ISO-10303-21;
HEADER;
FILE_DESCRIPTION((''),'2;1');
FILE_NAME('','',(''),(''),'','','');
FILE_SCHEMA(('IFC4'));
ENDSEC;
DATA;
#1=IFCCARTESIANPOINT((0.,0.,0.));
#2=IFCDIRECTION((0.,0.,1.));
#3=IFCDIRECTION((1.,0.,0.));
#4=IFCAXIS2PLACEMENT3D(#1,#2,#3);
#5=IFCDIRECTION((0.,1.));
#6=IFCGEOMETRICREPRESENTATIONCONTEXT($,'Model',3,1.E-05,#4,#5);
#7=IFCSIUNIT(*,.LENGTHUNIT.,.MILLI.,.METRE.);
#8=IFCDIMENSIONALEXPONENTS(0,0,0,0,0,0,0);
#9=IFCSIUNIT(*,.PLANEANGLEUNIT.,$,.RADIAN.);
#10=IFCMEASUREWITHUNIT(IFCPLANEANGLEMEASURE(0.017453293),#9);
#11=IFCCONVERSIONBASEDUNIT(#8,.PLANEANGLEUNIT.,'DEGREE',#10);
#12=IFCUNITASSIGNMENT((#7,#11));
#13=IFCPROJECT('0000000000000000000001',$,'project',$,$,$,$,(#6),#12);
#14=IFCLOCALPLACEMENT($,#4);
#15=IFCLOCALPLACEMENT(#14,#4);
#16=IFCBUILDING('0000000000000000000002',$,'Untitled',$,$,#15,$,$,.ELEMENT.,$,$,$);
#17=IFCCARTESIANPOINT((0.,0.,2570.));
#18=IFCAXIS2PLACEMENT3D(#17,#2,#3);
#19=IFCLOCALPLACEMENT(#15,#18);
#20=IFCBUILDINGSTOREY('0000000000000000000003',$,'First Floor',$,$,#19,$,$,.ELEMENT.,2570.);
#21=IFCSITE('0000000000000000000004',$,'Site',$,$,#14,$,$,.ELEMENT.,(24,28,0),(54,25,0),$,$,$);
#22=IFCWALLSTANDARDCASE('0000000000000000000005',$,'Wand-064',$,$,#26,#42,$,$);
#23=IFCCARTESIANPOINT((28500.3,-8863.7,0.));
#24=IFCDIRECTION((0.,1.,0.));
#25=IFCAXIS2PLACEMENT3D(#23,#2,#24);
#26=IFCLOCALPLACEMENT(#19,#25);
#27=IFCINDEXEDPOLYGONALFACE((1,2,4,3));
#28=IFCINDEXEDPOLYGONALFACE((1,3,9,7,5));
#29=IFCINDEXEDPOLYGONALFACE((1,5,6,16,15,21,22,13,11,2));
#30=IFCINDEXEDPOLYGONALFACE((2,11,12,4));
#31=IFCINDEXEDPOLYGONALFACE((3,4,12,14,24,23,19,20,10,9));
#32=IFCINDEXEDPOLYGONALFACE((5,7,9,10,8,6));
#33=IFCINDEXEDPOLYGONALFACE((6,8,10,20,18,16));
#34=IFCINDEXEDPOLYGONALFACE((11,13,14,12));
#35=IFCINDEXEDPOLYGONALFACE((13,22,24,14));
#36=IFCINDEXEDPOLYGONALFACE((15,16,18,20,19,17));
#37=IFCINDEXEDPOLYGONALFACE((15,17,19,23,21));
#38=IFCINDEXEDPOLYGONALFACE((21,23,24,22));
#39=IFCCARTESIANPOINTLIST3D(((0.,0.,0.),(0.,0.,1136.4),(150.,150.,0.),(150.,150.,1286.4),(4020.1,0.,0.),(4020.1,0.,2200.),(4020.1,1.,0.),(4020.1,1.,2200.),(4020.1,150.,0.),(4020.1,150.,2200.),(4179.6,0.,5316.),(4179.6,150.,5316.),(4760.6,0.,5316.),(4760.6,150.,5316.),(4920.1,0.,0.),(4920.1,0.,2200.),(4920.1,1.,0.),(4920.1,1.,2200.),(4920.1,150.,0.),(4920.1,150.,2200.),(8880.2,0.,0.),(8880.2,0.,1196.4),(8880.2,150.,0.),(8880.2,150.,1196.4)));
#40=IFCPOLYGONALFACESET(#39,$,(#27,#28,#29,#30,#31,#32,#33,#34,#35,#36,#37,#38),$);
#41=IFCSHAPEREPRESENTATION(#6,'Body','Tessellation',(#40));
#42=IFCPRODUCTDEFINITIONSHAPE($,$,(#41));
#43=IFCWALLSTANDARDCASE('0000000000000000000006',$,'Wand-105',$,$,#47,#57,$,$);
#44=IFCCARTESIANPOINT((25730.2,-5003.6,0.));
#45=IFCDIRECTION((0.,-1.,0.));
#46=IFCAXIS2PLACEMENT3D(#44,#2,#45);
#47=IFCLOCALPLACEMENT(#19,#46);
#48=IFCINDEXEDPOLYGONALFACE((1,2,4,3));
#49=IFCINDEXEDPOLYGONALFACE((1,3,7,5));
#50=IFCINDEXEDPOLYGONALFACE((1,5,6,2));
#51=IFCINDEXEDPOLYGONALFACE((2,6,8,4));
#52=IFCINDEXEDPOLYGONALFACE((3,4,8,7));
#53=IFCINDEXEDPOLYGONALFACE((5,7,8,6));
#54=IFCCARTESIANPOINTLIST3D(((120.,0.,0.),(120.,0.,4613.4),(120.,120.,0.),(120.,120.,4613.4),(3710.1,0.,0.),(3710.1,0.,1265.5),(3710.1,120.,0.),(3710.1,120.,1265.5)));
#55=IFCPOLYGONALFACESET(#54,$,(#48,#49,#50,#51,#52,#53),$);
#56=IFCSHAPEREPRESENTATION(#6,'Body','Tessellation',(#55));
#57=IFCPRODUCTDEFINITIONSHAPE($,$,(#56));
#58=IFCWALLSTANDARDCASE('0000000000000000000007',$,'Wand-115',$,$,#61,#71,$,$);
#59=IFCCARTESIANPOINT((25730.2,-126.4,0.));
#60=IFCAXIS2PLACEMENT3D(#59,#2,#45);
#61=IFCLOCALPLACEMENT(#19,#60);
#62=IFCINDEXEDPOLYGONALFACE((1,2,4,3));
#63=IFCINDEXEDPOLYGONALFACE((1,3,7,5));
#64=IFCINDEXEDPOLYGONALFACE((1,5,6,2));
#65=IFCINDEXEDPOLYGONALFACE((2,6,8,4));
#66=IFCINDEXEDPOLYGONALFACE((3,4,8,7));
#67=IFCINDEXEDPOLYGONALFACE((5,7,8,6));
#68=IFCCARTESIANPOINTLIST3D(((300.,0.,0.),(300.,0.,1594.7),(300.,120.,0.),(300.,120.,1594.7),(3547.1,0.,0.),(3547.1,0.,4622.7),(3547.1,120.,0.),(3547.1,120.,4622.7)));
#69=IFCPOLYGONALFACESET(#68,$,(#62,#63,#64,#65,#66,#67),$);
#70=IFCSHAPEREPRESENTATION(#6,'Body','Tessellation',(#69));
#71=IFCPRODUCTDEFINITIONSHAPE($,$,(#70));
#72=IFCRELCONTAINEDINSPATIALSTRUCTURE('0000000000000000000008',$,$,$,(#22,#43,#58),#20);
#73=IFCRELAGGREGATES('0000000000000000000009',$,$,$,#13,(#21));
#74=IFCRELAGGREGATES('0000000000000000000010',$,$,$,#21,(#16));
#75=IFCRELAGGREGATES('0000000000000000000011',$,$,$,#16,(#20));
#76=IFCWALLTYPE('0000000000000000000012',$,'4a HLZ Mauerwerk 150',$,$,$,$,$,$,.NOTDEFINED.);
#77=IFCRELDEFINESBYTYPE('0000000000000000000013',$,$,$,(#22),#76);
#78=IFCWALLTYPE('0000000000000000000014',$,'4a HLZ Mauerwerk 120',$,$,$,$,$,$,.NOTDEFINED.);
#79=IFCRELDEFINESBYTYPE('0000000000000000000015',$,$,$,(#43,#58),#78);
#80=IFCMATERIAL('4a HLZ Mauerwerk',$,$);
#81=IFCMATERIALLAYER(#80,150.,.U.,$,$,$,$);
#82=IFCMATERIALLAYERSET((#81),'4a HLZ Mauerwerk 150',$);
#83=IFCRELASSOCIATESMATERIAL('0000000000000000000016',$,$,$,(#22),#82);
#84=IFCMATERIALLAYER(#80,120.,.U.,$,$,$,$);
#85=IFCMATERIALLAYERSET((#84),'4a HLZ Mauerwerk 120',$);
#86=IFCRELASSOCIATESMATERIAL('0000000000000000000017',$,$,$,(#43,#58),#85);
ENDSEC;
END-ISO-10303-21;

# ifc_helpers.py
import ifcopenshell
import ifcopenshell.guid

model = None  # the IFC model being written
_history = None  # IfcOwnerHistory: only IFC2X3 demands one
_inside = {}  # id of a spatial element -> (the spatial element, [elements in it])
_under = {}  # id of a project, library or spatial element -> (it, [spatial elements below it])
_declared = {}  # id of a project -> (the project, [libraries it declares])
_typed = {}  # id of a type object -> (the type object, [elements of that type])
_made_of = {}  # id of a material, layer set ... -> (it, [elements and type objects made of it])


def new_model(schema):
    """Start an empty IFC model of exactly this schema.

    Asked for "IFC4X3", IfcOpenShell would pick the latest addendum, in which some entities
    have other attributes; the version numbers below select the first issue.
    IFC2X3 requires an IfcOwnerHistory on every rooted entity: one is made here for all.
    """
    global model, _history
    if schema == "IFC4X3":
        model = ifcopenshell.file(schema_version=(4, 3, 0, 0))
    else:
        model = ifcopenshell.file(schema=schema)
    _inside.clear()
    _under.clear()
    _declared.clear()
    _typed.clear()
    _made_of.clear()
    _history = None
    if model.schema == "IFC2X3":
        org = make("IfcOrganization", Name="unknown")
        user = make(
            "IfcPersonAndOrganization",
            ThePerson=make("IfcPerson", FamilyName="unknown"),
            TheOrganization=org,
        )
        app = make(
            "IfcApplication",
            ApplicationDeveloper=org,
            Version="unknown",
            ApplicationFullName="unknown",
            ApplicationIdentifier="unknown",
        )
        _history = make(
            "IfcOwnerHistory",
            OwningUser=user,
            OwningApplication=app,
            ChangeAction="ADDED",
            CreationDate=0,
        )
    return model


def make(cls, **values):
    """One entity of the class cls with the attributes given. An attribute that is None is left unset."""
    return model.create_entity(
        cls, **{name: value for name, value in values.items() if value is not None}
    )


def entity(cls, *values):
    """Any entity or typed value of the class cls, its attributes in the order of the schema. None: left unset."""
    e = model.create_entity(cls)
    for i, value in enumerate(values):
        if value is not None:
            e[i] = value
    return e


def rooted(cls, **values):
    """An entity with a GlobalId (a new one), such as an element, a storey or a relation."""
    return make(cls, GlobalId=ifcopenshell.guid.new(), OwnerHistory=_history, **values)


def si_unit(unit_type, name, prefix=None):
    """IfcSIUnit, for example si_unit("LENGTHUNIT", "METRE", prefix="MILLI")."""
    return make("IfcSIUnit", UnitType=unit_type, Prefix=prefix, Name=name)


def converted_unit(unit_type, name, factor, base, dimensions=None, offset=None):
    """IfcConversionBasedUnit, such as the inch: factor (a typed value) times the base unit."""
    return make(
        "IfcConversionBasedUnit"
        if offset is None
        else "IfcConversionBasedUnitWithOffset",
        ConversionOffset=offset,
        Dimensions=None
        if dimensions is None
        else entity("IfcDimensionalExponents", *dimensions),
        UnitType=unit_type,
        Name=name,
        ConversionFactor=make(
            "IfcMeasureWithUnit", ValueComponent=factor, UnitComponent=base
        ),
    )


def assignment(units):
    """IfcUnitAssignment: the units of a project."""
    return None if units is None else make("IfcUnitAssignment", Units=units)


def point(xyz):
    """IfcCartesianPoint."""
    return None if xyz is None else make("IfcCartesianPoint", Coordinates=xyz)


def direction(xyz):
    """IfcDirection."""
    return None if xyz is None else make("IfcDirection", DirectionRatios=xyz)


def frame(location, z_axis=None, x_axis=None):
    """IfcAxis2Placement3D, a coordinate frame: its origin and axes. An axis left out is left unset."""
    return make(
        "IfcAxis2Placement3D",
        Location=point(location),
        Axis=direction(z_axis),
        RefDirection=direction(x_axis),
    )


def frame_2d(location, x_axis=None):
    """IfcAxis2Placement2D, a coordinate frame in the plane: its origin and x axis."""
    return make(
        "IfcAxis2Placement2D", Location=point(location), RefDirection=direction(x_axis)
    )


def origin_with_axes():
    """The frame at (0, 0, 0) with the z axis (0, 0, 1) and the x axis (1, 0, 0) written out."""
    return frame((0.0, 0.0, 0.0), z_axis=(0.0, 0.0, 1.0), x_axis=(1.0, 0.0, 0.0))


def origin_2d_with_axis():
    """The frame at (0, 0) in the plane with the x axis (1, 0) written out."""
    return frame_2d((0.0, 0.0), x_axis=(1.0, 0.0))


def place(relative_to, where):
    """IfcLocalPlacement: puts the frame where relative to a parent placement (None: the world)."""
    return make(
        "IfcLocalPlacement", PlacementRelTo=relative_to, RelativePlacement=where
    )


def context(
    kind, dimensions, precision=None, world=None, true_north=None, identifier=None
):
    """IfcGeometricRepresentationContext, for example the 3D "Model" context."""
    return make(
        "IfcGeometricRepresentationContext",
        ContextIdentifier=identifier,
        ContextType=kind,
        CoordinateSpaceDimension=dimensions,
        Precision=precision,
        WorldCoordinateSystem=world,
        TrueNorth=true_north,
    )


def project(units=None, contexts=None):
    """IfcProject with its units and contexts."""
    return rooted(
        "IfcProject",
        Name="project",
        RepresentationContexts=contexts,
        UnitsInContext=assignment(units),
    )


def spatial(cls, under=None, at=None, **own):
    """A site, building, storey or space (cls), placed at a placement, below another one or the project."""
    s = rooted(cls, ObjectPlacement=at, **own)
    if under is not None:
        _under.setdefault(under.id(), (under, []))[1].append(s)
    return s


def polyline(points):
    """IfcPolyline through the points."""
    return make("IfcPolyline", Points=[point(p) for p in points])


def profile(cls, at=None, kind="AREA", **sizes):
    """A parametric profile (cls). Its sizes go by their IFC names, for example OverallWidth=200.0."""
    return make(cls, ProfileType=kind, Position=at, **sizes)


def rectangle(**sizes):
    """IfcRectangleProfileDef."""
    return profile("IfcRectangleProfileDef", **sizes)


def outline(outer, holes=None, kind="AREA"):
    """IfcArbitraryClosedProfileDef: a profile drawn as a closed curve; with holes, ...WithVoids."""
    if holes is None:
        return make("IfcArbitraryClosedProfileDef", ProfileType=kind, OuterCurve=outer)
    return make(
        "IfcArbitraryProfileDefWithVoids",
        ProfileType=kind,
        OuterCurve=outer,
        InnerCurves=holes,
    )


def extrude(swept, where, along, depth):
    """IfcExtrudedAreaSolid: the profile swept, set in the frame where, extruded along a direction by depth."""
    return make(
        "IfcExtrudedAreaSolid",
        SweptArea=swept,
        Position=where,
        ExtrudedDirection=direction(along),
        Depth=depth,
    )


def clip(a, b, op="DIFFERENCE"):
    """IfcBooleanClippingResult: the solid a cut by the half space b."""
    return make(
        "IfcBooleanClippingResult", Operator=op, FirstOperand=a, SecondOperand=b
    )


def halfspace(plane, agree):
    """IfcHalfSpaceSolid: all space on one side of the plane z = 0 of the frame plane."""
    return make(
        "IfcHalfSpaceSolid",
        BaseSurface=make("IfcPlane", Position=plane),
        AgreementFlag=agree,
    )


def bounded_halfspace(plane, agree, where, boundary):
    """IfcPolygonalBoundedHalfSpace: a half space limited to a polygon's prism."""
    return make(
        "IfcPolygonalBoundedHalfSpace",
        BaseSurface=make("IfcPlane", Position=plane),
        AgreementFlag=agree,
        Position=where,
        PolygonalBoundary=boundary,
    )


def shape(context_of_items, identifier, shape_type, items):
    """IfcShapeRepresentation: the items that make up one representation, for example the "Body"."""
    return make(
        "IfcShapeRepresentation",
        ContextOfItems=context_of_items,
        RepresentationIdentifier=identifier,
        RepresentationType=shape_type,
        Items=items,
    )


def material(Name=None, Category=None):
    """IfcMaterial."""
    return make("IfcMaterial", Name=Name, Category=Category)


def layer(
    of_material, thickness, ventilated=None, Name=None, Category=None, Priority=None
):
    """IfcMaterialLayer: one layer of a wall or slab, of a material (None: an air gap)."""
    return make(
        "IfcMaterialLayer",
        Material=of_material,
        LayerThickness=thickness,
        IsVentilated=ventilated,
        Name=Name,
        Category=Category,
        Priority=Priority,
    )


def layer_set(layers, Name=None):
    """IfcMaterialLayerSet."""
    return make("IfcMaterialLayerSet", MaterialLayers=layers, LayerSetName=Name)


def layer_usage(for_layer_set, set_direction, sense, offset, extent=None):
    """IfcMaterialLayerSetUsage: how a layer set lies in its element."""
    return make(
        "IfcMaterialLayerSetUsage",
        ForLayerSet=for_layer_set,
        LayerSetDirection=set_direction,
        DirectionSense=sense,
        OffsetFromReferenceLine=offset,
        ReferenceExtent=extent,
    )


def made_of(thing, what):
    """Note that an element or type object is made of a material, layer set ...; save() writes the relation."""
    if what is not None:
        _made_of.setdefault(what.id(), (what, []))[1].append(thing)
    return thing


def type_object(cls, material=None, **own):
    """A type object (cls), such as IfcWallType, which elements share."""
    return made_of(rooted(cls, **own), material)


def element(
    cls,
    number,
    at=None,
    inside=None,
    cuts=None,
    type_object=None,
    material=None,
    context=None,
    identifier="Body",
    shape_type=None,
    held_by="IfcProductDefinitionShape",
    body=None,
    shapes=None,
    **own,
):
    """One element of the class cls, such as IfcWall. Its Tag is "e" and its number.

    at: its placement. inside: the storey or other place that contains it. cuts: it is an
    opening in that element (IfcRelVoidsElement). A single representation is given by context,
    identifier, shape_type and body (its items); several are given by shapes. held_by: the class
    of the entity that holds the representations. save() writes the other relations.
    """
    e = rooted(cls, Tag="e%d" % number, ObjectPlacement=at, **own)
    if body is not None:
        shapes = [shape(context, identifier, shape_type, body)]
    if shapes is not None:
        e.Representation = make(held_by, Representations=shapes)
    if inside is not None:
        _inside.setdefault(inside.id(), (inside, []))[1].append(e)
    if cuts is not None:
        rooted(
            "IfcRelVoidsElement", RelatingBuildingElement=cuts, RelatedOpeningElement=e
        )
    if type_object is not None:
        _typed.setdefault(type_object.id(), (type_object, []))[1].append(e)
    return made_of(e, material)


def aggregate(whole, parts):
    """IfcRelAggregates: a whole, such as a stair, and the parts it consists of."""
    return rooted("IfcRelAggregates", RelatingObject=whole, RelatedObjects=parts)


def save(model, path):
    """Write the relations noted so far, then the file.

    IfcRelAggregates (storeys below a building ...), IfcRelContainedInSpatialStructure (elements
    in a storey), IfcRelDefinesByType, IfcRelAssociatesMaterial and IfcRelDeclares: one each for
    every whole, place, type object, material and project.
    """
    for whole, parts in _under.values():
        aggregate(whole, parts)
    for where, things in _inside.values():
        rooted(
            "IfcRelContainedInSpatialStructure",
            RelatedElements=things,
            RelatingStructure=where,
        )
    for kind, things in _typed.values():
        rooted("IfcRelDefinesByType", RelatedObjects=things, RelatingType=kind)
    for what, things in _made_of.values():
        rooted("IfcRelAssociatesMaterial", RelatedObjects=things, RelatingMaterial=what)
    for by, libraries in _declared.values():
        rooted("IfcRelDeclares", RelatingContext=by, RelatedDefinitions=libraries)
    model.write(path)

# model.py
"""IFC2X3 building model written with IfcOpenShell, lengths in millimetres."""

from ifc_helpers import new_model, entity, si_unit, converted_unit, direction, frame, origin_with_axes, origin_2d_with_axis, place, context, project, spatial, polyline, rectangle, outline, extrude, clip, halfspace, bounded_halfspace, material, layer, layer_set, layer_usage, type_object, element, save


model = new_model("IFC2X3")

# Units and contexts
model_context = context("Model", 3, precision=1e-05, world=origin_with_axes(), true_north=direction((0.0, 1.0)))
ifc_project = project(units=[si_unit("LENGTHUNIT", "METRE", prefix="MILLI"), converted_unit("PLANEANGLEUNIT", "DEGREE", entity("IfcPlaneAngleMeasure", 0.017453293), si_unit("PLANEANGLEUNIT", "RADIAN"), dimensions=[0, 0, 0, 0, 0, 0, 0])], contexts=[model_context])

# Site, building, storey
site_placement = place(None, origin_with_axes())
site = spatial("IfcSite", under=ifc_project, at=site_placement, Name="Site", CompositionType="ELEMENT", RefLatitude=(24, 28, 0), RefLongitude=(54, 25, 0))
building_placement = place(site_placement, origin_with_axes())
building = spatial("IfcBuilding", under=site, at=building_placement, Name="Untitled", CompositionType="ELEMENT")
storey_placement = place(building_placement, frame((0.0, 0.0, 2570.0), z_axis=(0.0, 0.0, 1.0), x_axis=(1.0, 0.0, 0.0)))
storey = spatial("IfcBuildingStorey", under=building, at=storey_placement, Name="First Floor", CompositionType="ELEMENT", Elevation=2570.0)

# Shared definitions
ifc_material_1 = material(Name="4a HLZ Mauerwerk")
ifc_layer_1 = layer(ifc_material_1, 150.0, ventilated="UNKNOWN")
ifc_layer_set_1 = layer_set([ifc_layer_1], Name="4a HLZ Mauerwerk 150")
wall_type_1 = type_object("IfcWallType", Name="4a HLZ Mauerwerk 150", PredefinedType="NOTDEFINED")

# Wall, opening
ifc_layer_usage_1 = layer_usage(ifc_layer_set_1, "AXIS2", "POSITIVE", 0.0)
wall_1_placement = place(storey_placement, frame((28500.3, -8863.7, 0.0), z_axis=(0.0, 0.0, 1.0), x_axis=(0.0, 1.0, 0.0)))
wall_1 = element("IfcWallStandardCase", 1, at=wall_1_placement, inside=storey, type_object=wall_type_1, material=ifc_layer_usage_1, Name="Wand-064", context=model_context, shape_type="Clipping", body=[
    clip(clip(extrude(outline(polyline([(0.0, 0.0), (8880.2, 0.0), (8880.2, 150.0), (150.0, 150.0), (0.0, 0.0)])), origin_with_axes(), (0.0, 0.0, 1.0), 5316.0), bounded_halfspace(frame((5038.3, 0.0, 5038.3), z_axis=(-0.707107, 0.0, -0.707107), x_axis=(0.707107, 0.0, -0.707107)), True, origin_with_axes(), polyline([(4470.1, 0.0), (8880.2, 0.0), (8880.2, 150.0), (4470.1, 150.0), (4470.1, 0.0)]))), bounded_halfspace(frame((-568.2, 0.0, 568.2), z_axis=(0.707107, 0.0, -0.707107), x_axis=(0.707107, 0.0, 0.707107)), True, origin_with_axes(), polyline([(0.0, 0.0), (4470.1, 0.0), (4470.1, 150.0), (0.0, 150.0), (0.0, 0.0)]))),
])
opening_1_placement = place(wall_1_placement, frame((4470.1, 0.0, 0.0), z_axis=(0.0, 0.0, 1.0), x_axis=(1.0, 0.0, 0.0)))
element("IfcOpeningElement", 2, at=opening_1_placement, cuts=wall_1, context=model_context, shape_type="SweptSolid", body=[
    extrude(rectangle(XDim=900.0, YDim=2200.0, at=origin_2d_with_axis()), frame((0.0, -301.0, 1100.0), z_axis=(0.0, 1.0, 0.0), x_axis=(1.0, 0.0, 0.0)), (0.0, 0.0, 1.0), 302.0),
    extrude(rectangle(XDim=900.0, YDim=2200.0, at=origin_2d_with_axis()), frame((0.0, 301.0, 1100.0), z_axis=(0.0, -1.0, 0.0), x_axis=(1.0, 0.0, 0.0)), (0.0, 0.0, 1.0), 302.0),
])

# Walls
ifc_layer_2 = layer(ifc_material_1, 120.0, ventilated="UNKNOWN")
ifc_layer_set_2 = layer_set([ifc_layer_2], Name="4a HLZ Mauerwerk 120")
ifc_layer_usage_2 = layer_usage(ifc_layer_set_2, "AXIS2", "POSITIVE", 0.0)
wall_type_2 = type_object("IfcWallType", Name="4a HLZ Mauerwerk 120", PredefinedType="NOTDEFINED")
wall_2_placement = place(storey_placement, frame((25730.2, -5003.6, 0.0), z_axis=(0.0, 0.0, 1.0), x_axis=(0.0, -1.0, 0.0)))
element("IfcWallStandardCase", 3, at=wall_2_placement, inside=storey, type_object=wall_type_2, material=ifc_layer_usage_2, Name="Wand-105", context=model_context, shape_type="Clipping", body=[
    clip(extrude(outline(polyline([(120.0, 0.0), (3710.1, 0.0), (3710.1, 120.0), (120.0, 120.0), (120.0, 0.0)])), origin_with_axes(), (0.0, 0.0, 1.0), 5316.0), halfspace(frame((2356.9, 0.0, 2527.4), z_axis=(-0.681998, 0.0, -0.731354), x_axis=(0.731354, 0.0, -0.681998)), True)),
])
ifc_layer_usage_3 = layer_usage(ifc_layer_set_2, "AXIS2", "POSITIVE", 0.0)
wall_3_placement = place(storey_placement, frame((25730.2, -126.4, 0.0), z_axis=(0.0, 0.0, 1.0), x_axis=(0.0, -1.0, 0.0)))
element("IfcWallStandardCase", 4, at=wall_3_placement, inside=storey, type_object=wall_type_2, material=ifc_layer_usage_3, Name="Wand-115", context=model_context, shape_type="Clipping", body=[
    clip(extrude(outline(polyline([(300.0, 0.0), (3547.1, 0.0), (3547.1, 120.0), (300.0, 120.0), (300.0, 0.0)])), origin_with_axes(), (0.0, 0.0, 1.0), 5316.0), halfspace(frame((-655.9, 0.0, 703.3), z_axis=(0.681998, 0.0, -0.731354), x_axis=(0.731354, 0.0, 0.681998)), True)),
])

save(model, "model.ifc")
